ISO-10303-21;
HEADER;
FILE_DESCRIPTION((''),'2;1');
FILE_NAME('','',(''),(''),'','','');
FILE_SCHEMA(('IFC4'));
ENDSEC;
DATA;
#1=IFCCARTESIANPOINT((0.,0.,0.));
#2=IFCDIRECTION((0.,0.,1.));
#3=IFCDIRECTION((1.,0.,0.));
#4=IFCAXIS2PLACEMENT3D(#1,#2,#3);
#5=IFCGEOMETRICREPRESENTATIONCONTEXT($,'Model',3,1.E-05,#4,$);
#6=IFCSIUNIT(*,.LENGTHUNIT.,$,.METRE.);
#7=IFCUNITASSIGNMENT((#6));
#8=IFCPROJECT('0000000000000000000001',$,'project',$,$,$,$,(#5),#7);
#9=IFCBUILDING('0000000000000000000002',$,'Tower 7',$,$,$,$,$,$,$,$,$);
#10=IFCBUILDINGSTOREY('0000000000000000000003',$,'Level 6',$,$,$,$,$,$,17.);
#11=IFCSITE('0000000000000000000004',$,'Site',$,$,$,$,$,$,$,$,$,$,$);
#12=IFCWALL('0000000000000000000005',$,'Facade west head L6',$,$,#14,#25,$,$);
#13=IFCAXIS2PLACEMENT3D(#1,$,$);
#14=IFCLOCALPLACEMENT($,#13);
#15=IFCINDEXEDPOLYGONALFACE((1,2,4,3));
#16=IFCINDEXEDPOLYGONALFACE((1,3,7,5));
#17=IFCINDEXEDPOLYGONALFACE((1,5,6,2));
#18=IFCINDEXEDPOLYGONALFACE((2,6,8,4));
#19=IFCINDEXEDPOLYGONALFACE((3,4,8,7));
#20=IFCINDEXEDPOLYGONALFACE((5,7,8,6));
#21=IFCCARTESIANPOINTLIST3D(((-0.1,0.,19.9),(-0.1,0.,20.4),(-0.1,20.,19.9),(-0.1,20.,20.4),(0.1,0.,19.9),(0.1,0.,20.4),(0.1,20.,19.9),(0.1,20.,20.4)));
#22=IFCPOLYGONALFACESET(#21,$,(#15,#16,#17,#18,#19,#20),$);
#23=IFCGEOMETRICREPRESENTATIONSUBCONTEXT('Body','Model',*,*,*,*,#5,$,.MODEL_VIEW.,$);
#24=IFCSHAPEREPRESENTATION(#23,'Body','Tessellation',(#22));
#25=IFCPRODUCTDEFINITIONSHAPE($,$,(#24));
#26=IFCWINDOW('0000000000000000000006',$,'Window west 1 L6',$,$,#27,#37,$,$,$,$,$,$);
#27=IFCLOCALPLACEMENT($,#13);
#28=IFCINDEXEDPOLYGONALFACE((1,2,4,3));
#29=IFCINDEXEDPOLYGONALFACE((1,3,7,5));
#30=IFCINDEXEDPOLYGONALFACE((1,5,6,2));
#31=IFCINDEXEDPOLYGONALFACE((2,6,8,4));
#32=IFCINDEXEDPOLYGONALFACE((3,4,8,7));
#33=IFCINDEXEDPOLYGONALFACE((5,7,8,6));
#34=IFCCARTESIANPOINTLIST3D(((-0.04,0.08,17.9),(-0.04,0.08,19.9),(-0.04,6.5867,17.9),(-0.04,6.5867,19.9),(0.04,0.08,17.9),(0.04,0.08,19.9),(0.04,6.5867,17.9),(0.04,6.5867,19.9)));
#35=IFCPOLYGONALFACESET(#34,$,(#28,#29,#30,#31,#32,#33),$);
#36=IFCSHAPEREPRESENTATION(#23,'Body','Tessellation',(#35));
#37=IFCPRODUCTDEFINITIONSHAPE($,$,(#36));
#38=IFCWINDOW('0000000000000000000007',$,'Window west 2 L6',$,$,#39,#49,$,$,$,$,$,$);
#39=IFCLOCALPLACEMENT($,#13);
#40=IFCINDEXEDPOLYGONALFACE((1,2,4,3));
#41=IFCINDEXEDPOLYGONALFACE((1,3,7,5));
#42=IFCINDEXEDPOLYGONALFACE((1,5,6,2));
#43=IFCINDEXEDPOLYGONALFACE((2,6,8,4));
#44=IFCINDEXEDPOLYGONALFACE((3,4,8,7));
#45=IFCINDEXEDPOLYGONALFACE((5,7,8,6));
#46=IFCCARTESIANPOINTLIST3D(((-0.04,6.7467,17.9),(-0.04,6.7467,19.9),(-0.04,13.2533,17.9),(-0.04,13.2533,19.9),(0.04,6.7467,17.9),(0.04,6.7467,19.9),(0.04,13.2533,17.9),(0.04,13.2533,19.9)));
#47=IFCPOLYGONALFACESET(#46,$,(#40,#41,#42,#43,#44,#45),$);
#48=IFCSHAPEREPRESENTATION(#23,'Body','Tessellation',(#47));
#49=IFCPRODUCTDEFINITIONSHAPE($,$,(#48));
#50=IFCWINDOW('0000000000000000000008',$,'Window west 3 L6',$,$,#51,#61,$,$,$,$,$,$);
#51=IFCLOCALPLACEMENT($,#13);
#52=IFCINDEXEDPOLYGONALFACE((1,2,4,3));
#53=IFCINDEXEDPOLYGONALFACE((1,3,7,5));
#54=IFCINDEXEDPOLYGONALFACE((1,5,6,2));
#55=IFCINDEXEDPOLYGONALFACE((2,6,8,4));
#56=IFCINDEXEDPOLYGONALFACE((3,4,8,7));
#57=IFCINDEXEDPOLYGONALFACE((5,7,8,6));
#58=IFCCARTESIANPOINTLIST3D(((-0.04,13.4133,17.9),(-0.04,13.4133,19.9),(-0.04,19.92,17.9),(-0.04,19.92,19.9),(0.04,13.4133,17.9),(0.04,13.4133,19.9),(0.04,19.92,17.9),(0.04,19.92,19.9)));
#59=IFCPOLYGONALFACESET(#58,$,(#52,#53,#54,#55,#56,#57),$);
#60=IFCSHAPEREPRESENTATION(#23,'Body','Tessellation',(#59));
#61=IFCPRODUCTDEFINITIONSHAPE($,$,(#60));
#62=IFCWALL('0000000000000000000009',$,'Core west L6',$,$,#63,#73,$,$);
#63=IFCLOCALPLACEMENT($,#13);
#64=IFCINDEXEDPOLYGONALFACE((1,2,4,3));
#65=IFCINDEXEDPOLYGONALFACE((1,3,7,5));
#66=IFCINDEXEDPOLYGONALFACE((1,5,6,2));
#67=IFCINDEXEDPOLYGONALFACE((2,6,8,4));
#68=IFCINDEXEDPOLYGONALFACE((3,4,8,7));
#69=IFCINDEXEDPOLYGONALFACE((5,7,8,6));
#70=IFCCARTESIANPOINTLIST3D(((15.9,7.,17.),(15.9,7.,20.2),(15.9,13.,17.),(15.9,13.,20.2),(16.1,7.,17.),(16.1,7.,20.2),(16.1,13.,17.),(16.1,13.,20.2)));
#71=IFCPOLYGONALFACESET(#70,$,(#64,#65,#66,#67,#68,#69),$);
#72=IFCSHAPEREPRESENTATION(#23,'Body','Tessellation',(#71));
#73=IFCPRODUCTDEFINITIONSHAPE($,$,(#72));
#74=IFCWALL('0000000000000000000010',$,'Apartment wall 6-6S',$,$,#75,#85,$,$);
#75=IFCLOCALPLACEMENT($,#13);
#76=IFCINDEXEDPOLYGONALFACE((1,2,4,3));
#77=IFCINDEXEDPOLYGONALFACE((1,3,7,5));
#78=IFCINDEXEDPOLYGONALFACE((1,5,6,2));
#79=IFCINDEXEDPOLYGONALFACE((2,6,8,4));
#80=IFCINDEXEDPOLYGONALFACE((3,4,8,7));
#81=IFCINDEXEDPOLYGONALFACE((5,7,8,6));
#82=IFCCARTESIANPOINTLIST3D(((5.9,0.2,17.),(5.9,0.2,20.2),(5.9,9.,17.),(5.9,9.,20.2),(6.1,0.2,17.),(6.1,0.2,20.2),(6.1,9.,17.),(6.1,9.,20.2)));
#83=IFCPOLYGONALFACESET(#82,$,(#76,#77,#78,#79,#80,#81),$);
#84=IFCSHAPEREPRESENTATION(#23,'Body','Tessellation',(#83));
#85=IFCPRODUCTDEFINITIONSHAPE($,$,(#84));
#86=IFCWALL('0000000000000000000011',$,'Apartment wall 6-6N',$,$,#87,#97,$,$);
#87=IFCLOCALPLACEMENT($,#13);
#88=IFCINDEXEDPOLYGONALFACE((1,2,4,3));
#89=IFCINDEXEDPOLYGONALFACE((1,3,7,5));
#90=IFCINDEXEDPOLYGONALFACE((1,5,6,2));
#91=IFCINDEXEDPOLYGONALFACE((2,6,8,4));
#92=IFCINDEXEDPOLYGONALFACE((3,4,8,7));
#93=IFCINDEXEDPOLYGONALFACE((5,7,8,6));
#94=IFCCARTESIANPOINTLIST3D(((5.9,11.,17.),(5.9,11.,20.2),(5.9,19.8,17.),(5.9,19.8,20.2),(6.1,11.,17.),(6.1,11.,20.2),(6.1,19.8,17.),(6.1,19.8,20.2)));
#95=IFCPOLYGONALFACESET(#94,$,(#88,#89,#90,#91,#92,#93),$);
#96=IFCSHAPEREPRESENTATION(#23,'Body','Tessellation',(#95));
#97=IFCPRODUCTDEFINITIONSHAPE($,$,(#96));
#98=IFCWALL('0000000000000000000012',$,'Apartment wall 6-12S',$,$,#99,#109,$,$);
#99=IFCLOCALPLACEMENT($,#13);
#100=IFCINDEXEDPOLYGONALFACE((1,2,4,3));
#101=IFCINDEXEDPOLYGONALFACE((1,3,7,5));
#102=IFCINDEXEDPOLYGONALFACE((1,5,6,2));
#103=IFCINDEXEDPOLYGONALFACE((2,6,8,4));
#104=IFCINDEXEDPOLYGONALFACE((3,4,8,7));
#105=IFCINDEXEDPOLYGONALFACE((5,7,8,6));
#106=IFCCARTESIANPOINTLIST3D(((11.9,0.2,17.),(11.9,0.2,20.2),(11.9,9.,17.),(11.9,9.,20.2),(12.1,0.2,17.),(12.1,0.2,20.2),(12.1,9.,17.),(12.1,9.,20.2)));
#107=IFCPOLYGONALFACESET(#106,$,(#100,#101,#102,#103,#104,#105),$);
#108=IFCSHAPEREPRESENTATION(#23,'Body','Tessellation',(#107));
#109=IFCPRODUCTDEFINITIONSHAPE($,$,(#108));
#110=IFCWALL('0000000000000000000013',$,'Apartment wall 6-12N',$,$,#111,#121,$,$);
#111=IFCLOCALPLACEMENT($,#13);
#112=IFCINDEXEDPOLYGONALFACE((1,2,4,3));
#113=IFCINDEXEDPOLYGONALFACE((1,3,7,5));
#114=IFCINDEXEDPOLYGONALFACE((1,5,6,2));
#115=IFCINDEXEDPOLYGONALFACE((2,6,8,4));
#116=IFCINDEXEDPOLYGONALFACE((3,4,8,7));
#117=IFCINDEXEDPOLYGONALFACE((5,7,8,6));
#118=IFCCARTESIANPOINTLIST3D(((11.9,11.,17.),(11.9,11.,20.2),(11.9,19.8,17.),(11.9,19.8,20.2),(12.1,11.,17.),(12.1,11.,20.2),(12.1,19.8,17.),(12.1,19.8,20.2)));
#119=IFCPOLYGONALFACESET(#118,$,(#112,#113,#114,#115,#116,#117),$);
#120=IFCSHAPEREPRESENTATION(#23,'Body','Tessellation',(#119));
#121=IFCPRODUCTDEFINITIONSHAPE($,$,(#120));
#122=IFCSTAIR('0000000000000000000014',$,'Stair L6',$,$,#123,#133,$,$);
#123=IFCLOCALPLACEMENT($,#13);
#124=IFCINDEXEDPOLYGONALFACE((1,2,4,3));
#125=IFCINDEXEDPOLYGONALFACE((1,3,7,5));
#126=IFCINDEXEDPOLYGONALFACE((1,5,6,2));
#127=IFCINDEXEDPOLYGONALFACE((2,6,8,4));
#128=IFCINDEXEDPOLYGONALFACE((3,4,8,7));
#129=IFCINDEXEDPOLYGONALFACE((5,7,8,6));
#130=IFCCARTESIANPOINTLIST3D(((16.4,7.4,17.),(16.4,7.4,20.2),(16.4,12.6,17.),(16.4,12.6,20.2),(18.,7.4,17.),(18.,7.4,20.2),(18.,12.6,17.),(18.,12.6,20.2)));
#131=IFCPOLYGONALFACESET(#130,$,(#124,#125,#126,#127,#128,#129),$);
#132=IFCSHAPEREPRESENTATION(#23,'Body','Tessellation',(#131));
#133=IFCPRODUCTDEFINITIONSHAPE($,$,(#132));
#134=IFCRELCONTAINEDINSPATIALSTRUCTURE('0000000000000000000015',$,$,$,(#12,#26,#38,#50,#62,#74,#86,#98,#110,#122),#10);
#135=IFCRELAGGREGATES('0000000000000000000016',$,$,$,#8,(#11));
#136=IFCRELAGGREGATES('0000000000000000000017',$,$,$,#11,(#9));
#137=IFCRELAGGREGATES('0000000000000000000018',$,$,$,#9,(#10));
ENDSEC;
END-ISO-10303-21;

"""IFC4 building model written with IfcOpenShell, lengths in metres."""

from ifc_helpers import new_model, si_unit, frame, origin, origin_with_axes, origin_2d, place, context, subcontext, project, spatial, rectangle, extrude, element, save


model = new_model("IFC4")

# Units and contexts
model_context = context("Model", 3, precision=1e-05, world=origin_with_axes())
body_context = subcontext(model_context, "Body", "Model", "MODEL_VIEW")
ifc_project = project(units=[si_unit("LENGTHUNIT", "METRE")], contexts=[model_context])

# Site, building, storey
site = spatial("IfcSite", under=ifc_project, Name="Site")
building = spatial("IfcBuilding", under=site, Name="Tower 7")
storey = spatial("IfcBuildingStorey", under=building, Name="Level 6", Elevation=17.0)

# Wall
wall_1_placement = place(None, frame((0.0, 10.0, 19.9), z_axis=(0.0, 0.0, 1.0), x_axis=(1.0, 0.0, 0.0)))
element("IfcWall", 1, at=wall_1_placement, inside=storey, Name="Facade west head L6", context=body_context, shape_type="SweptSolid", body=[
    extrude(rectangle(XDim=0.2, YDim=20.0, at=origin_2d()), origin(), (0.0, 0.0, 1.0), 0.5),
])

# Windows
for number, where, z_axis, x_axis, name in (
    (2, (0.0, 3.3333, 17.9), (0.0, 0.0, 1.0), (1.0, 0.0, 0.0), "Window west 1 L6"),
    (3, (0.0, 10.0, 17.9), (0.0, 0.0, 1.0), (1.0, 0.0, 0.0), "Window west 2 L6"),
):
    element("IfcWindow", number, at=place(None, frame(where, z_axis=z_axis, x_axis=x_axis)), inside=storey, Name=name, context=body_context, shape_type="SweptSolid", body=[
        extrude(rectangle(XDim=0.08, YDim=6.5067, at=origin_2d()), origin(), (0.0, 0.0, 1.0), 2.0),
    ])
window_1_placement = place(None, frame((0.0, 16.6667, 17.9), z_axis=(0.0, 0.0, 1.0), x_axis=(1.0, 0.0, 0.0)))
element("IfcWindow", 4, at=window_1_placement, inside=storey, Name="Window west 3 L6", context=body_context, shape_type="SweptSolid", body=[
    extrude(rectangle(XDim=0.08, YDim=6.5067, at=origin_2d()), origin(), (0.0, 0.0, 1.0), 2.0),
])

# Walls
wall_2_placement = place(None, frame((16.0, 10.0, 17.0), z_axis=(0.0, 0.0, 1.0), x_axis=(1.0, 0.0, 0.0)))
element("IfcWall", 5, at=wall_2_placement, inside=storey, Name="Core west L6", context=body_context, shape_type="SweptSolid", body=[
    extrude(rectangle(XDim=0.2, YDim=6.0, at=origin_2d()), origin(), (0.0, 0.0, 1.0), 3.2),
])
for number, where, z_axis, x_axis, name in (
    (6, (6.0, 4.6, 17.0), (0.0, 0.0, 1.0), (1.0, 0.0, 0.0), "Apartment wall 6-6S"),
    (7, (6.0, 15.4, 17.0), (0.0, 0.0, 1.0), (1.0, 0.0, 0.0), "Apartment wall 6-6N"),
    (8, (12.0, 4.6, 17.0), (0.0, 0.0, 1.0), (1.0, 0.0, 0.0), "Apartment wall 6-12S"),
    (9, (12.0, 15.4, 17.0), (0.0, 0.0, 1.0), (1.0, 0.0, 0.0), "Apartment wall 6-12N"),
):
    element("IfcWall", number, at=place(None, frame(where, z_axis=z_axis, x_axis=x_axis)), inside=storey, Name=name, context=body_context, shape_type="SweptSolid", body=[
        extrude(rectangle(XDim=0.2, YDim=8.8, at=origin_2d()), origin(), (0.0, 0.0, 1.0), 3.2),
    ])

# Stair
stair_placement = place(None, frame((17.2, 10.0, 17.0), z_axis=(0.0, 0.0, 1.0), x_axis=(1.0, 0.0, 0.0)))
element("IfcStair", 10, at=stair_placement, inside=storey, Name="Stair L6", context=body_context, shape_type="SweptSolid", body=[
    extrude(rectangle(XDim=1.6, YDim=5.2, at=origin_2d()), origin(), (0.0, 0.0, 1.0), 3.2),
])

save(model, "model.ifc")
